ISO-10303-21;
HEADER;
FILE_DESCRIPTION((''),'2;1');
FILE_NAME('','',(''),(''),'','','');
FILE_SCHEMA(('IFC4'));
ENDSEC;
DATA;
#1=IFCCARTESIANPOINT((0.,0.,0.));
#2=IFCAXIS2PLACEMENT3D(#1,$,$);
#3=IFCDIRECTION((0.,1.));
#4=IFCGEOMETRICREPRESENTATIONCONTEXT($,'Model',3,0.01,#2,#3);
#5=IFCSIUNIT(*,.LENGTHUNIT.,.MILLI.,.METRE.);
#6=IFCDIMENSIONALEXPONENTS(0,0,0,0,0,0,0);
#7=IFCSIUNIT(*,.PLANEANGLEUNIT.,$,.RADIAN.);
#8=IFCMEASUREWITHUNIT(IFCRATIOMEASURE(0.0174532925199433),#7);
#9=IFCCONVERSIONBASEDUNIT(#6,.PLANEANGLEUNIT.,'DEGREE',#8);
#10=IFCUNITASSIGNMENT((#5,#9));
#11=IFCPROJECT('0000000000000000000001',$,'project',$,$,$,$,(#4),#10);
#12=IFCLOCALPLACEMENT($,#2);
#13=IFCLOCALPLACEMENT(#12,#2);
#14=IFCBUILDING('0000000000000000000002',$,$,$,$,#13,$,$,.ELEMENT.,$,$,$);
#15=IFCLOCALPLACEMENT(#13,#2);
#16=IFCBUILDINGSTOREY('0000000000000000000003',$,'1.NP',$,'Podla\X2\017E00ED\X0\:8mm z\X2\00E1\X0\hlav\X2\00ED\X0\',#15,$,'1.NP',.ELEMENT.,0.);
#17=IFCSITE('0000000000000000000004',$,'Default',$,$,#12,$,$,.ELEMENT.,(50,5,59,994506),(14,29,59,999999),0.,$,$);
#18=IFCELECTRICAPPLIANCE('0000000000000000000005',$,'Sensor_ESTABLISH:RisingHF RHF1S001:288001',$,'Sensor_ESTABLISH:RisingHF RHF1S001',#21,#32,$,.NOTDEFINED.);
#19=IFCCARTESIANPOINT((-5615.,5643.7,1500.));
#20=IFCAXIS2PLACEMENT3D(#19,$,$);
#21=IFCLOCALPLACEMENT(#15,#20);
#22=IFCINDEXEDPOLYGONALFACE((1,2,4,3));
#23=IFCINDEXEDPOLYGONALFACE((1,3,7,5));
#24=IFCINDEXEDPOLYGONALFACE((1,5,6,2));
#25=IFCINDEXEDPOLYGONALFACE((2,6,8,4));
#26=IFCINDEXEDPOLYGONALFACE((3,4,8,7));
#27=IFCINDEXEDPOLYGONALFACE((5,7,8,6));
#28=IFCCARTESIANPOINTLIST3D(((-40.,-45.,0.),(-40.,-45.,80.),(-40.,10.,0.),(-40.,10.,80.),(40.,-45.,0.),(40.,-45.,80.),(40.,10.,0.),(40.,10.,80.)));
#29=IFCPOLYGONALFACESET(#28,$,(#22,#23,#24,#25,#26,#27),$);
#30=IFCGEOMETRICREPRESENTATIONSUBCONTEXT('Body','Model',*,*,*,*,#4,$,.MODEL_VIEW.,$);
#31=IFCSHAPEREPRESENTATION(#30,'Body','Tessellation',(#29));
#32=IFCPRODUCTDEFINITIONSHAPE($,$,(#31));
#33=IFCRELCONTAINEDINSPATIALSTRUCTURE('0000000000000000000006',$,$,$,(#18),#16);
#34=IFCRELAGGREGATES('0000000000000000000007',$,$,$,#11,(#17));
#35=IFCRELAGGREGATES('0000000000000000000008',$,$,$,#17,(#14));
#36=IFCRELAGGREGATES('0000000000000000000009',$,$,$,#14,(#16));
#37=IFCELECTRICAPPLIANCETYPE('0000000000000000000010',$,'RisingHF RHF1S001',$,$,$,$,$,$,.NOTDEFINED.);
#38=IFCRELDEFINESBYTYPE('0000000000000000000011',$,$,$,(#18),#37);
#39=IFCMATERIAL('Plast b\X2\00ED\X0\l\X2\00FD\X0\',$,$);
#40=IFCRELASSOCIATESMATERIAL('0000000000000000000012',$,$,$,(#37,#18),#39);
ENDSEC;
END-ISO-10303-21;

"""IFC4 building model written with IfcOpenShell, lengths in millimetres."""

from ifc_helpers import new_model, entity, si_unit, converted_unit, direction, frame, frame_2d, origin, place, context, subcontext, project, spatial, rectangle, extrude, source, transform, mapped, material, type_object, type_shapes, element, save


model = new_model("IFC4")

# Units and contexts
model_context = context("Model", 3, precision=0.01, world=origin(), true_north=direction((0.0, 1.0)))
body_context = subcontext(model_context, "Body", "Model", "MODEL_VIEW")
ifc_project = project(units=[si_unit("LENGTHUNIT", "METRE", prefix="MILLI"), converted_unit("PLANEANGLEUNIT", "DEGREE", entity("IfcRatioMeasure", 0.0174532925199433), si_unit("PLANEANGLEUNIT", "RADIAN"), dimensions=[0, 0, 0, 0, 0, 0, 0])], contexts=[model_context])

# Site, building, storey
site_placement = place(None, origin())
site = spatial("IfcSite", under=ifc_project, at=site_placement, Name="Default", CompositionType="ELEMENT", RefLatitude=(50, 5, 59, 994506), RefLongitude=(14, 29, 59, 999999), RefElevation=0.0)
building_placement = place(site_placement, origin())
building = spatial("IfcBuilding", under=site, at=building_placement, CompositionType="ELEMENT")
storey_placement = place(building_placement, origin())
storey = spatial("IfcBuildingStorey", under=building, at=storey_placement, Name="1.NP", ObjectType="Podlaží:8mm záhlaví", LongName="1.NP", CompositionType="ELEMENT", Elevation=0.0)

# Shared definitions
ifc_material_1 = material(Name="Plast bílý")

# Electric appliance
electric_appliance_type = type_object("IfcElectricApplianceType", Name="RisingHF RHF1S001", PredefinedType="NOTDEFINED", material=ifc_material_1)
shared_shape_1 = source(origin(), body_context, "Body", "SweptSolid", [
    extrude(rectangle(XDim=80.0, YDim=55.0, at=frame_2d((0.0, 0.0), x_axis=(1.0, 0.0))), frame((0.0, -17.5, 0.0), z_axis=(0.0, 0.0, 1.0), x_axis=(-1.0, 0.0, 0.0)), (0.0, 0.0, 1.0), 80.0),
])
type_shapes(electric_appliance_type, [shared_shape_1])
electric_appliance_placement = place(storey_placement, frame((-5615.0, 5643.7, 1500.0)))
element("IfcElectricAppliance", 1, at=electric_appliance_placement, inside=storey, type_object=electric_appliance_type, material=ifc_material_1, Name="Sensor_ESTABLISH:RisingHF RHF1S001:288001", ObjectType="Sensor_ESTABLISH:RisingHF RHF1S001", PredefinedType="NOTDEFINED", context=body_context, shape_type="MappedRepresentation", body=[
    mapped(shared_shape_1, transform((0.0, 0.0, 0.0), scale=1.0)),
])

save(model, "model.ifc")
